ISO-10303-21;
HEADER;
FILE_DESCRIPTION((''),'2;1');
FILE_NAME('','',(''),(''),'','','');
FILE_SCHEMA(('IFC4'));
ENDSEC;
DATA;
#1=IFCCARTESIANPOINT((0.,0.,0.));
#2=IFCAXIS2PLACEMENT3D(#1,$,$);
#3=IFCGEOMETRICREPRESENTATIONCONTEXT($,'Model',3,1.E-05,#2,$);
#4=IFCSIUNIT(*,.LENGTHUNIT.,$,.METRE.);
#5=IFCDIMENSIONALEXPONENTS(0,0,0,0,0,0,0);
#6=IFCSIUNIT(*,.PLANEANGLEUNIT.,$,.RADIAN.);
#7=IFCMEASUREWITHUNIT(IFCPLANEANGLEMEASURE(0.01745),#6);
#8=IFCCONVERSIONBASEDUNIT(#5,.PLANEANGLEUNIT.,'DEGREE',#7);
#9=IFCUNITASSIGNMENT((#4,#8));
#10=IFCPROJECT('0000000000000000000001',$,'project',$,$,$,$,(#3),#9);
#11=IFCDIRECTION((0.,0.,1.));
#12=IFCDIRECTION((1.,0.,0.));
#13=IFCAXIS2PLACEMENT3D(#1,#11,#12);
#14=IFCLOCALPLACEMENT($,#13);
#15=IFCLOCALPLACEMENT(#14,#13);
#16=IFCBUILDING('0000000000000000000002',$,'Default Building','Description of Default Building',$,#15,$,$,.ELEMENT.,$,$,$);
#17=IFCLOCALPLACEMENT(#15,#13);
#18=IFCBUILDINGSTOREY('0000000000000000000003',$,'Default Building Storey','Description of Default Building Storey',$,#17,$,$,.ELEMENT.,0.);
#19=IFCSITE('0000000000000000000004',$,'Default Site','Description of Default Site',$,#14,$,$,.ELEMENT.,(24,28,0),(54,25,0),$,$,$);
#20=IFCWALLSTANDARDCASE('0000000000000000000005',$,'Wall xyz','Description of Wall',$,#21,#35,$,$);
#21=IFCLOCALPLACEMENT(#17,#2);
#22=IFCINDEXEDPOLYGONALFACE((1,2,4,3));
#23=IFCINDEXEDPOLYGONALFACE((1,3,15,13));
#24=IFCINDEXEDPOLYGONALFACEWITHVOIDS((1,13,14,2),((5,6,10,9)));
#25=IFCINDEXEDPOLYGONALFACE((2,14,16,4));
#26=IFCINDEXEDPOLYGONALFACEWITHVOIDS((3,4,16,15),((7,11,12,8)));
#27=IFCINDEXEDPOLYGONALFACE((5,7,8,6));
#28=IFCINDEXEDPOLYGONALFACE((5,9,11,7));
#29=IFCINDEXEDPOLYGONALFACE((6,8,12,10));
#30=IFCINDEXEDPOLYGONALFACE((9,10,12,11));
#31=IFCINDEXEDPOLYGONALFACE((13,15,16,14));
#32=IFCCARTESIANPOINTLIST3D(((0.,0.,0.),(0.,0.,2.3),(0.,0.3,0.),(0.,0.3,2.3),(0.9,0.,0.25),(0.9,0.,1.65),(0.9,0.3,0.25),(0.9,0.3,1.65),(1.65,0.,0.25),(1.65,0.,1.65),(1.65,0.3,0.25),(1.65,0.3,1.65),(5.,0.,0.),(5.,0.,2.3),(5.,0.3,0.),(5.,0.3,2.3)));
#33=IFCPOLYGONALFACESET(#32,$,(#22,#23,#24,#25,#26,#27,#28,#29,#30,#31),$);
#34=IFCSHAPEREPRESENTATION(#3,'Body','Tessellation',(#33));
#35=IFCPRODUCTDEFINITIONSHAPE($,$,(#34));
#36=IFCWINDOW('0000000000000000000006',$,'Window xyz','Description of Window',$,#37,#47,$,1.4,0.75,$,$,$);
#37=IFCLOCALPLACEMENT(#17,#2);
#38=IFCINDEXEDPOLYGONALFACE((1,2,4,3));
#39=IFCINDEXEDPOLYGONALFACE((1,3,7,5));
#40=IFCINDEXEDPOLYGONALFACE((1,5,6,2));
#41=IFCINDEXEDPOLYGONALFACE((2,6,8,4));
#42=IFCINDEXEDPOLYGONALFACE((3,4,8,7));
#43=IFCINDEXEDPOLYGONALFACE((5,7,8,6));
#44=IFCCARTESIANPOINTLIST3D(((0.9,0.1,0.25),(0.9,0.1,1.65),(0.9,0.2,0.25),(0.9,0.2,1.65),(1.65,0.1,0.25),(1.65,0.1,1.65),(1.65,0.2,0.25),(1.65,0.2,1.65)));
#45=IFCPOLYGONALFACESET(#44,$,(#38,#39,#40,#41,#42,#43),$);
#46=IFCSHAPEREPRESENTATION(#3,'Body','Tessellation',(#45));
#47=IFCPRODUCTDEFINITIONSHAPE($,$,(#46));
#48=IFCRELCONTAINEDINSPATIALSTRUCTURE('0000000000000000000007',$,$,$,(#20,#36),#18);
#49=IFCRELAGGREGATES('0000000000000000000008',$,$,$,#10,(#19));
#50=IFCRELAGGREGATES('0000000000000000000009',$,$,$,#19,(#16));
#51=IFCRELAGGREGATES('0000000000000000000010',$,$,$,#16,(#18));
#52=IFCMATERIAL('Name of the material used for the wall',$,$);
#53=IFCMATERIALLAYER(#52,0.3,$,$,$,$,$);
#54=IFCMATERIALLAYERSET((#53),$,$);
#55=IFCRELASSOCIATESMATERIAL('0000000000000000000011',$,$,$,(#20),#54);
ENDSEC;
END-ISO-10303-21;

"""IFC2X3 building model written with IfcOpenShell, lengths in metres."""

from ifc_helpers import new_model, entity, si_unit, converted_unit, frame, origin, origin_with_axes, place, context, project, spatial, polyline, outline, extrude, material, layer, layer_set, layer_usage, element, fill, save


model = new_model("IFC2X3")

# Units and contexts
model_context = context("Model", 3, precision=1e-05, world=origin())
ifc_project = project(units=[si_unit("LENGTHUNIT", "METRE"), converted_unit("PLANEANGLEUNIT", "DEGREE", entity("IfcPlaneAngleMeasure", 0.01745), si_unit("PLANEANGLEUNIT", "RADIAN"), dimensions=[0, 0, 0, 0, 0, 0, 0])], contexts=[model_context])

# Site, building, storey
site_placement = place(None, origin_with_axes())
site = spatial("IfcSite", under=ifc_project, at=site_placement, Name="Default Site", Description="Description of Default Site", CompositionType="ELEMENT", RefLatitude=(24, 28, 0), RefLongitude=(54, 25, 0))
building_placement = place(site_placement, origin_with_axes())
building = spatial("IfcBuilding", under=site, at=building_placement, Name="Default Building", Description="Description of Default Building", CompositionType="ELEMENT")
storey_placement = place(building_placement, origin_with_axes())
storey = spatial("IfcBuildingStorey", under=building, at=storey_placement, Name="Default Building Storey", Description="Description of Default Building Storey", CompositionType="ELEMENT", Elevation=0.0)

# Wall, opening, window
ifc_material = material(Name="Name of the material used for the wall")
ifc_layer = layer(ifc_material, 0.3)
ifc_layer_set = layer_set([ifc_layer])
ifc_layer_usage = layer_usage(ifc_layer_set, "AXIS2", "POSITIVE", -0.15)
wall_placement = place(storey_placement, origin_with_axes())
wall = element("IfcWallStandardCase", 1, at=wall_placement, inside=storey, material=ifc_layer_usage, Name="Wall xyz", Description="Description of Wall", context=model_context, shape_type="SweptSolid", body=[
    extrude(outline(polyline([(0.0, 0.0), (0.0, 0.3), (5.0, 0.3), (5.0, 0.0), (0.0, 0.0)])), origin_with_axes(), (0.0, 0.0, 1.0), 2.3),
])
opening_placement = place(wall_placement, frame((0.9, 0.0, 0.25), z_axis=(0.0, 0.0, 1.0), x_axis=(1.0, 0.0, 0.0)))
opening = element("IfcOpeningElement", 2, at=opening_placement, cuts=wall, context=model_context, shape_type="SweptSolid", body=[
    extrude(outline(polyline([(0.0, 0.0), (0.0, 0.3), (0.75, 0.3), (0.75, 0.0), (0.0, 0.0)])), origin_with_axes(), (0.0, 0.0, 1.0), 1.4),
])
window_placement = place(opening_placement, frame((0.0, 0.1, 0.0), z_axis=(0.0, 0.0, 1.0), x_axis=(1.0, 0.0, 0.0)))
window = element("IfcWindow", 3, at=window_placement, inside=storey, Name="Window xyz", Description="Description of Window", OverallHeight=1.4, OverallWidth=0.75, context=model_context, shape_type="SweptSolid", body=[
    extrude(outline(polyline([(0.0, 0.0), (0.0, 0.1), (0.75, 0.1), (0.75, 0.0), (0.0, 0.0)])), origin_with_axes(), (0.0, 0.0, 1.0), 1.4),
])
fill(opening, window)

save(model, "model.ifc")
